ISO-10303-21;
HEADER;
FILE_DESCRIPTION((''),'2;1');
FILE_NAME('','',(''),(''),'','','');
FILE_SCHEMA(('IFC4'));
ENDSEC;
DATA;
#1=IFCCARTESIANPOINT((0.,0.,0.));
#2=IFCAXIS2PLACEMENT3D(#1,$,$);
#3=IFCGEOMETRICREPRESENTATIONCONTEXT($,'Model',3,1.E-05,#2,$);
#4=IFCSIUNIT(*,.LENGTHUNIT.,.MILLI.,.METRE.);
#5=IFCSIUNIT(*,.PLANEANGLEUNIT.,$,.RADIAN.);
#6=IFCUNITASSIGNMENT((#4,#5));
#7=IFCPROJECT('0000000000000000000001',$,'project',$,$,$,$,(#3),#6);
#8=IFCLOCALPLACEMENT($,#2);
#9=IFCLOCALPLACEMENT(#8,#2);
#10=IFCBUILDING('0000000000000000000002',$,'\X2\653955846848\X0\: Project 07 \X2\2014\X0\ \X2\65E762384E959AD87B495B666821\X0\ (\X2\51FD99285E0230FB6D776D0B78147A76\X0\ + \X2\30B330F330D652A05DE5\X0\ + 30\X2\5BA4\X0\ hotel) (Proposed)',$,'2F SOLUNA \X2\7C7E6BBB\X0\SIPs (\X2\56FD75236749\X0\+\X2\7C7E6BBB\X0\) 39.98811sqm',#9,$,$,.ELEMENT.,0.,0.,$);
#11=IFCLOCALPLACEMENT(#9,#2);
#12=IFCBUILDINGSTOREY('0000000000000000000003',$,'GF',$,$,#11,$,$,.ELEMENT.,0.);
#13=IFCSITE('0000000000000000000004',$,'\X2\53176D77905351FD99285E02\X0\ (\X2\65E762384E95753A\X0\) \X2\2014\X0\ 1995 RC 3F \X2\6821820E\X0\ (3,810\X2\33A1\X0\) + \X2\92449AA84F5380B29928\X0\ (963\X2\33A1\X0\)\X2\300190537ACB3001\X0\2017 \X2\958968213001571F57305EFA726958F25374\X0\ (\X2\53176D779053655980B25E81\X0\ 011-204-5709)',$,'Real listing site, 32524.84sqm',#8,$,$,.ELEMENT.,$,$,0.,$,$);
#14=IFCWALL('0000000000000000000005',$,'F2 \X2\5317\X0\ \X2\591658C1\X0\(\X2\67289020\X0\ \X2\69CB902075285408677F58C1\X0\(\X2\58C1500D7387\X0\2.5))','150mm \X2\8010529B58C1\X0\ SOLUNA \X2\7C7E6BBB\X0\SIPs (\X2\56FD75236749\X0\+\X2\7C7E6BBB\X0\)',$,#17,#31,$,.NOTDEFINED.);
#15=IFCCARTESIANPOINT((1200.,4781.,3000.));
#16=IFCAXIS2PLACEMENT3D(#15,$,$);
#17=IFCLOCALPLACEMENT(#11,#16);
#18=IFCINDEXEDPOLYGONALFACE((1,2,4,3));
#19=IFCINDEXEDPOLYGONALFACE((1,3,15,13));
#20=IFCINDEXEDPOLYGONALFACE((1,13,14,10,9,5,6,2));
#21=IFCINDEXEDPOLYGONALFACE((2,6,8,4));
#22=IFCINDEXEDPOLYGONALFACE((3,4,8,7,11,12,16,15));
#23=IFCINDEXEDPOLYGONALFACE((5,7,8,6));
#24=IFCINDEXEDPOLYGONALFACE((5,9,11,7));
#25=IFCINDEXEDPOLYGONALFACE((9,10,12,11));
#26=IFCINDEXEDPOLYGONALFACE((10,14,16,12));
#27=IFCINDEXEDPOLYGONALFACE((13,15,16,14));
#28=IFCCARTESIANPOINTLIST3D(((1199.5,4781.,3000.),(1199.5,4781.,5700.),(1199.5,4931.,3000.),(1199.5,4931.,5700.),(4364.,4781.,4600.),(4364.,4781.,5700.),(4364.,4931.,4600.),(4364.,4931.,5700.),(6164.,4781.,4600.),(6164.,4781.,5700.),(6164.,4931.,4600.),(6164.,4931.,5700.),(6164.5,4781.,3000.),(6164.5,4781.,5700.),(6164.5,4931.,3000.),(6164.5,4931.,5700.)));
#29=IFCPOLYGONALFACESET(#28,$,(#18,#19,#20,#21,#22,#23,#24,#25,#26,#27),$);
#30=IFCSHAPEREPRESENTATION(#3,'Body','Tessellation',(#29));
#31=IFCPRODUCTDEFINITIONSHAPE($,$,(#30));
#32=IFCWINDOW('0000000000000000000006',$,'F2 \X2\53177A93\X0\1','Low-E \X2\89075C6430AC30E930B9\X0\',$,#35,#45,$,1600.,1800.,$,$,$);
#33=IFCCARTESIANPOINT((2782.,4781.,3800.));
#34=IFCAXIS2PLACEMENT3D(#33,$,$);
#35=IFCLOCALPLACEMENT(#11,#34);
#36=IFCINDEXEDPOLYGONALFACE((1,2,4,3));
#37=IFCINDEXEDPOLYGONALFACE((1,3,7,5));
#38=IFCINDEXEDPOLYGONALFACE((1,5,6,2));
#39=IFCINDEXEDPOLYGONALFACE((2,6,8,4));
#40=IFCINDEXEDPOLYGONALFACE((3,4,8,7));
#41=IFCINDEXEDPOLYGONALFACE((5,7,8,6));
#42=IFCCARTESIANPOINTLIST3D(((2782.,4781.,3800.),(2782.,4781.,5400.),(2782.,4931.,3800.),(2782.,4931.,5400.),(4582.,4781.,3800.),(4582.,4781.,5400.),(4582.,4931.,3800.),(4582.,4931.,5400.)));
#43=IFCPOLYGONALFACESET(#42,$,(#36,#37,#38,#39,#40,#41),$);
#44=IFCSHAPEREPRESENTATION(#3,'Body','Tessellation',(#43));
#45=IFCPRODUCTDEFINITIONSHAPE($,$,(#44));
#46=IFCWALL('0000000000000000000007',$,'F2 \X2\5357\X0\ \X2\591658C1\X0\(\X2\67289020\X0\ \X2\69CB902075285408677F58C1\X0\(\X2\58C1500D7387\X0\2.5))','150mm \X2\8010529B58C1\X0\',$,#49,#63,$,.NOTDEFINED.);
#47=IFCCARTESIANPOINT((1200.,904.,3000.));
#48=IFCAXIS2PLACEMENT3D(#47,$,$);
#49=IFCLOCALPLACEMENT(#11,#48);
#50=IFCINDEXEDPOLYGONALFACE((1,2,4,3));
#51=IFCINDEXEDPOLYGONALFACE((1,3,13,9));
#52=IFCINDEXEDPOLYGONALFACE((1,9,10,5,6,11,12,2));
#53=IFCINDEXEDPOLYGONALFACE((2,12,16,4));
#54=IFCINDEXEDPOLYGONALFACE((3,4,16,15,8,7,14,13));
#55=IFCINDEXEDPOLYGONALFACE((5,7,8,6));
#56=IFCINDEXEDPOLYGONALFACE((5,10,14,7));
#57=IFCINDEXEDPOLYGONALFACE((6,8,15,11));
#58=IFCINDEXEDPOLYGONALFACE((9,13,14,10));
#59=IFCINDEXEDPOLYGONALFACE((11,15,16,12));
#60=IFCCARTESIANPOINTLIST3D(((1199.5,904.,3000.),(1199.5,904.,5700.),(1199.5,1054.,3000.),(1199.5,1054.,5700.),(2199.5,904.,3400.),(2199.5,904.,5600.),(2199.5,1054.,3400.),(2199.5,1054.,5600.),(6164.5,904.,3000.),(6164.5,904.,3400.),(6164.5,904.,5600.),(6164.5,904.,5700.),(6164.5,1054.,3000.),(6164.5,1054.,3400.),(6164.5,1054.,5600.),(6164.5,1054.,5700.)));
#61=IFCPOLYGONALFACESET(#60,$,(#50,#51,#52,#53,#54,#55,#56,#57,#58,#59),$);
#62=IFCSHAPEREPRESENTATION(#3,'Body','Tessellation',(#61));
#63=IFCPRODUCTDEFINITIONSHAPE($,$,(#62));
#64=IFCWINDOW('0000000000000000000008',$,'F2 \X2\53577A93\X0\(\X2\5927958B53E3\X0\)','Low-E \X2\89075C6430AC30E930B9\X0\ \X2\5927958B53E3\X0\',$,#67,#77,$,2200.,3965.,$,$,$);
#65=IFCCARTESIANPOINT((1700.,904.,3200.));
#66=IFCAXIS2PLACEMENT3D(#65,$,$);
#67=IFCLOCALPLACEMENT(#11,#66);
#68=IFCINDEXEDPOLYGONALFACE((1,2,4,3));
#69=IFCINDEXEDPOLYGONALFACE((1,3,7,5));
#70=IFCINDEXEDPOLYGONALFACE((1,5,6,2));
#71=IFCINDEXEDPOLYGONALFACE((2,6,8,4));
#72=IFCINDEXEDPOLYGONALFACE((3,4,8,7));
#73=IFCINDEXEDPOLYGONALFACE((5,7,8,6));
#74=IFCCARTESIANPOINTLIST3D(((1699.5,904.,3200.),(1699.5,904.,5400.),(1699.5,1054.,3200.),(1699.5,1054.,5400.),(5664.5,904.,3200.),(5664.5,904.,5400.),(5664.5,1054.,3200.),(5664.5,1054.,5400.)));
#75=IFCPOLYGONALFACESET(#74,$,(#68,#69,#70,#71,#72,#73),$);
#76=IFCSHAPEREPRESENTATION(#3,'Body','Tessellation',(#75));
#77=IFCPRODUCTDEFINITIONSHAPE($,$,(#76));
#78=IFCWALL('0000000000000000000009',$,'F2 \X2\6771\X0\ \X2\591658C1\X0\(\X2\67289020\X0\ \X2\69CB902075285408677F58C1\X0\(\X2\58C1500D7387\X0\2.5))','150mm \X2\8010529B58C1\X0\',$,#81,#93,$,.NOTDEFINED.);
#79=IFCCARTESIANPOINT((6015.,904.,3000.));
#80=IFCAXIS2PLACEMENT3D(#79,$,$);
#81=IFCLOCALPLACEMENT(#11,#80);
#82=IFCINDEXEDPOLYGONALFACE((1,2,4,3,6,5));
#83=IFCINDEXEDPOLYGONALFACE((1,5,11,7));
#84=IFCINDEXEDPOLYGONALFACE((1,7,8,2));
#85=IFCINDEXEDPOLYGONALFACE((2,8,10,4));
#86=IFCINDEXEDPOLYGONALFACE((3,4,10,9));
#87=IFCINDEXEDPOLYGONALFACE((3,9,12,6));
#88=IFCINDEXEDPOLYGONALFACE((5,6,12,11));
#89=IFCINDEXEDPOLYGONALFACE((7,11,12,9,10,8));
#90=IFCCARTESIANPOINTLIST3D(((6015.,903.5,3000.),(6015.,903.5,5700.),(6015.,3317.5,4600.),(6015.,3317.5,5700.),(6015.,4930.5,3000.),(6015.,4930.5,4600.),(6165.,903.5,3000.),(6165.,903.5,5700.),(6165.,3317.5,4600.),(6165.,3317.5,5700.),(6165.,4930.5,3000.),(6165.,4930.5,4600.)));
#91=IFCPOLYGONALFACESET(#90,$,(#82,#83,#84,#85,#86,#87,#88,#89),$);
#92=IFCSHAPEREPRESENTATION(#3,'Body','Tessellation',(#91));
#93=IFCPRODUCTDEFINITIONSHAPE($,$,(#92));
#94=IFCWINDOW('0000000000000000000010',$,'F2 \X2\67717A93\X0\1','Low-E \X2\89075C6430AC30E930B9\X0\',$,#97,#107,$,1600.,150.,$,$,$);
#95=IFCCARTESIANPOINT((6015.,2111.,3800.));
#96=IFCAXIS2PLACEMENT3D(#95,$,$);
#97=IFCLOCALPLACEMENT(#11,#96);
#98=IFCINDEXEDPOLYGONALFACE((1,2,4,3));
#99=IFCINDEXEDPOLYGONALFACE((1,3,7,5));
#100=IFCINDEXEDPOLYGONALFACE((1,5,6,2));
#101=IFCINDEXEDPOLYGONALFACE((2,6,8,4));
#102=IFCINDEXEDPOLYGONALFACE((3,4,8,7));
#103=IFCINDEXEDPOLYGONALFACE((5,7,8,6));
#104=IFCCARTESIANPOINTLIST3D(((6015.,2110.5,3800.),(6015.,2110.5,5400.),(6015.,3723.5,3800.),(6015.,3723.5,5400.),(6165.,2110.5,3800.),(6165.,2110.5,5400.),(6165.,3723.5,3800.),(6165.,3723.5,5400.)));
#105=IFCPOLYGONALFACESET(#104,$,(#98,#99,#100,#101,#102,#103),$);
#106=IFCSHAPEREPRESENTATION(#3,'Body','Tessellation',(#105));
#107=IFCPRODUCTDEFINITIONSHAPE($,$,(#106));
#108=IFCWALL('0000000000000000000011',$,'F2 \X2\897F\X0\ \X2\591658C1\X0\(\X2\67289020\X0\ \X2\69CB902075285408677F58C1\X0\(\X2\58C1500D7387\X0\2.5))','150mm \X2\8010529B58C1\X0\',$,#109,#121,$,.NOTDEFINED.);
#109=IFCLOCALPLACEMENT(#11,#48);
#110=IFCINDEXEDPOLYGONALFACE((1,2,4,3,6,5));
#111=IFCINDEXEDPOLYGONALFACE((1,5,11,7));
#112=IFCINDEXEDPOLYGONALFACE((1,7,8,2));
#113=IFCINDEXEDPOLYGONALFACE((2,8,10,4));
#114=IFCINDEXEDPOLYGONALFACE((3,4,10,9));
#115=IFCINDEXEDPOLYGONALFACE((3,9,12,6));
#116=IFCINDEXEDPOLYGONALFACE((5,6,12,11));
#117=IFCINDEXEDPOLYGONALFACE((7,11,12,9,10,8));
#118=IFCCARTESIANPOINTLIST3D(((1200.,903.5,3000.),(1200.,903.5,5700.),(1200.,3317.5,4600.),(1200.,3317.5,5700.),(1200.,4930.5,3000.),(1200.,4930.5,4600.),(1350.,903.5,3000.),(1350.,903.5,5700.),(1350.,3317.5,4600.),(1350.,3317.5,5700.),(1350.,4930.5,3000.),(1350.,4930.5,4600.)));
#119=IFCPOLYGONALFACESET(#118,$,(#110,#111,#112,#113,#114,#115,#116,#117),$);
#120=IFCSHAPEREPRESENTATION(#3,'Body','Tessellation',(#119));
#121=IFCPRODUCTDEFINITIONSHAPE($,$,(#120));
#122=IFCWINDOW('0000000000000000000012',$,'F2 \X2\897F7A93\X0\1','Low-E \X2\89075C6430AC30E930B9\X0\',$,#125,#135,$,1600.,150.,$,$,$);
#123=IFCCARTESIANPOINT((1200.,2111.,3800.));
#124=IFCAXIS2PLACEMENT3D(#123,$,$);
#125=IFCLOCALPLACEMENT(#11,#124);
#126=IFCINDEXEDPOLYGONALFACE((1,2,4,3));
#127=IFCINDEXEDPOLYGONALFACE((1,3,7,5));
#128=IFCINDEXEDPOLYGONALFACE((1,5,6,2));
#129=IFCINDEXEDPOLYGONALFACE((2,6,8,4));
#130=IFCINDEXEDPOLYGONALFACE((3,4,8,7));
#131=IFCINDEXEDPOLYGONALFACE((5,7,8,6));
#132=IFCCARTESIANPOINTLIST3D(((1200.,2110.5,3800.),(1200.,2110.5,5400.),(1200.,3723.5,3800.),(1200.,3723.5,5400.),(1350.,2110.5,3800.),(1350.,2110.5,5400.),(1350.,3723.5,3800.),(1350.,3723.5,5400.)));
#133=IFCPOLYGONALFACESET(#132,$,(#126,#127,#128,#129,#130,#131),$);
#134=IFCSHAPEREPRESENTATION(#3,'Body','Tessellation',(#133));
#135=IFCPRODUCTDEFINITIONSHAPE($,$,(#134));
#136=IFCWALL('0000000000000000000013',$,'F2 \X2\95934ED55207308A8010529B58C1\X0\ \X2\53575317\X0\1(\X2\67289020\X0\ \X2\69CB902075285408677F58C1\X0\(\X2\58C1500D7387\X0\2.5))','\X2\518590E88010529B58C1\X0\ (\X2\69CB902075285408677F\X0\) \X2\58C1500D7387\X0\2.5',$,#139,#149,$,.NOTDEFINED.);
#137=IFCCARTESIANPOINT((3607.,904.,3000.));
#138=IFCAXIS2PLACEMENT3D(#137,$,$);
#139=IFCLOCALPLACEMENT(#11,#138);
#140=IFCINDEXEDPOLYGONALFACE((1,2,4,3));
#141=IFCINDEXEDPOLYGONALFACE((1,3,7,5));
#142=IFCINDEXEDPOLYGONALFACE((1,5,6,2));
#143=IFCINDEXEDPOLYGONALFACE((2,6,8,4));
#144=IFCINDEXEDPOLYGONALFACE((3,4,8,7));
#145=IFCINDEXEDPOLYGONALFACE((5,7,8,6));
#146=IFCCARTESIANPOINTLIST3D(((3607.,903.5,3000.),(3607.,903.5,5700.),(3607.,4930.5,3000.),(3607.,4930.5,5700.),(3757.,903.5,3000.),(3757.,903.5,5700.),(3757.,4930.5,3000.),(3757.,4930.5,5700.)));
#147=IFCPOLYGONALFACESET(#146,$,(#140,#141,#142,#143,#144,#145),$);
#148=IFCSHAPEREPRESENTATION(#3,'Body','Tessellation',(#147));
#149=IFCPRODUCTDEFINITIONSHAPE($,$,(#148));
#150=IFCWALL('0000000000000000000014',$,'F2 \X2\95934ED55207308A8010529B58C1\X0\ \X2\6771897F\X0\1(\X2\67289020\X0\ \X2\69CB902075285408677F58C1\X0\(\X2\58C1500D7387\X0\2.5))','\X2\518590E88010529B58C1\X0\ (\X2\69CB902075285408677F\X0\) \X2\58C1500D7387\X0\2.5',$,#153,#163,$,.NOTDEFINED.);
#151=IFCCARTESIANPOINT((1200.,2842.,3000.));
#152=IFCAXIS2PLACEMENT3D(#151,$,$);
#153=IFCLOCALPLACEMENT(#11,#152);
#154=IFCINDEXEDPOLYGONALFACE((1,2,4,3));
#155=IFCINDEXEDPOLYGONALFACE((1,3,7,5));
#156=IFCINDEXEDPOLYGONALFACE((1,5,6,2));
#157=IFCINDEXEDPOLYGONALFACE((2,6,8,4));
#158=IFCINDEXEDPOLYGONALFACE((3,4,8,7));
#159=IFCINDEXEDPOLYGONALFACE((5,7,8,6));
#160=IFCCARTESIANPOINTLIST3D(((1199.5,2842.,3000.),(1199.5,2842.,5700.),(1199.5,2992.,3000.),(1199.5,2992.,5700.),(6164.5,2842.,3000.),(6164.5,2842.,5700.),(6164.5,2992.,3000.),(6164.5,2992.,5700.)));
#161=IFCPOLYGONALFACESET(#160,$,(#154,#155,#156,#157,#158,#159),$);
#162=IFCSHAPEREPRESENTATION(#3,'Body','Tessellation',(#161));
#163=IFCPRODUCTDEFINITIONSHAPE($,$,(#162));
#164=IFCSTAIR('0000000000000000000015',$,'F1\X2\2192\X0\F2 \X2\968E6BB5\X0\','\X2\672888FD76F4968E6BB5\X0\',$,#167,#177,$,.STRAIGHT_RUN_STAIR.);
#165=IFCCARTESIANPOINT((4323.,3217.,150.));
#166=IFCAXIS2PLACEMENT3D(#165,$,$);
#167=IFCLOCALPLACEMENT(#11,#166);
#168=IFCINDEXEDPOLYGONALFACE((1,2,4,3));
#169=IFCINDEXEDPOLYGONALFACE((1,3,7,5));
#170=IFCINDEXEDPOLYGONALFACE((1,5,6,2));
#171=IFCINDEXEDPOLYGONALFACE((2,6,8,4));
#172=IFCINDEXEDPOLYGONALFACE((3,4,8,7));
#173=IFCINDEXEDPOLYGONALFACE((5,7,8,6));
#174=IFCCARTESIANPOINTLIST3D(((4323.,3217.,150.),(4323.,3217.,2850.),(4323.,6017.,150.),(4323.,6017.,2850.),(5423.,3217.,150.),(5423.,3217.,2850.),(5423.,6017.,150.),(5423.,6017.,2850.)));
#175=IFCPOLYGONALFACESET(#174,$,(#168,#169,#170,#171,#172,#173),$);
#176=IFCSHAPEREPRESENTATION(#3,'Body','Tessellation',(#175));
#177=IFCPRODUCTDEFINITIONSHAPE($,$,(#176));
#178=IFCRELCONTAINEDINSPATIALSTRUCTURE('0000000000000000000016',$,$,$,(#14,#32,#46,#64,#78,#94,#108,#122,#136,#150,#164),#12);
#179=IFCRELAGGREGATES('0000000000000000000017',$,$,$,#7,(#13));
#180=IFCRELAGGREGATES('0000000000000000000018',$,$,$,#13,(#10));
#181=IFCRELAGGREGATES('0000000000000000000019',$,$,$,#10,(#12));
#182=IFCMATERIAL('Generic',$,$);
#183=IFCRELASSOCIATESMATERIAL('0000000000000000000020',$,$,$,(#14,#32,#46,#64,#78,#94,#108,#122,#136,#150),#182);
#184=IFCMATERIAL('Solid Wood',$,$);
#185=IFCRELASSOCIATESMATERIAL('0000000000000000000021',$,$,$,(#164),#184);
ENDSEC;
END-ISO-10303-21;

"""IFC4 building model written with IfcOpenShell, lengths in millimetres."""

from ifc_helpers import new_model, si_unit, frame, frame_2d, origin, place, context, project, spatial, rectangle, extrude, material, element, fill, save


model = new_model("IFC4")

# Units and contexts
model_context = context("Model", 3, precision=1e-05, world=origin())
ifc_project = project(units=[si_unit("LENGTHUNIT", "METRE", prefix="MILLI"), si_unit("PLANEANGLEUNIT", "RADIAN")], contexts=[model_context])

# Site, building, storey
site_placement = place(None, origin())
site = spatial("IfcSite", under=ifc_project, at=site_placement, Name="北海道函館市 (旧戸井町) — 1995 RC 3F 校舎 (3,810㎡) + 鉄骨体育館 (963㎡)、道立、2017 閉校、土地建物売却 (北海道教育庁 011-204-5709)", ObjectType="Real listing site, 32524.84sqm", CompositionType="ELEMENT", RefElevation=0.0)
building_placement = place(site_placement, origin())
building = spatial("IfcBuilding", under=site, at=building_placement, Name="改善案: Project 07 — 旧戸井高等学校 (函館市・海洋研究 + コンブ加工 + 30室 hotel) (Proposed)", ObjectType="2F SOLUNA 籾殻SIPs (国産杉+籾殻) 39.98811sqm", CompositionType="ELEMENT", ElevationOfRefHeight=0.0, ElevationOfTerrain=0.0)
storey_placement = place(building_placement, origin())
storey = spatial("IfcBuildingStorey", under=building, at=storey_placement, Name="GF", CompositionType="ELEMENT", Elevation=0.0)

# Shared definitions
ifc_material_1 = material(Name="Generic")

# Shared definitions
ifc_material_2 = material(Name="Solid Wood")

# Walls, openings, windows
wall_1_placement = place(storey_placement, frame((1200.0, 4781.0, 3000.0)))
wall_1 = element("IfcWall", 1, at=wall_1_placement, inside=storey, material=ifc_material_1, Name="F2 北 外壁(木造 構造用合板壁(壁倍率2.5))", Description="150mm 耐力壁 SOLUNA 籾殻SIPs (国産杉+籾殻)", PredefinedType="NOTDEFINED", context=model_context, shape_type="SweptSolid", body=[
    extrude(rectangle(XDim=4965.0, YDim=150.0, at=frame_2d((2482.0, 75.0))), frame((1200.0, 4781.0, 3000.0)), (0.0, 0.0, 1.0), 2700.0),
])
opening_1_placement = place(storey_placement, frame((2782.0, 4781.0, 3800.0)))
opening_1 = element("IfcOpeningElement", 2, at=opening_1_placement, cuts=wall_1, PredefinedType="NOTDEFINED", context=model_context, shape_type="SweptSolid", body=[
    extrude(rectangle(XDim=1800.0, YDim=150.0, at=frame_2d((900.0, 75.0))), frame((2782.0, 4781.0, 3800.0)), (0.0, 0.0, 1.0), 1600.0),
])
window_1_placement = place(storey_placement, frame((2782.0, 4781.0, 3800.0)))
window_1 = element("IfcWindow", 3, at=window_1_placement, inside=storey, material=ifc_material_1, Name="F2 北窓1", Description="Low-E 複層ガラス", OverallHeight=1600.0, OverallWidth=1800.0, context=model_context, shape_type="SweptSolid", body=[
    extrude(rectangle(XDim=1800.0, YDim=150.0, at=frame_2d((900.0, 75.0))), frame((2782.0, 4781.0, 3800.0)), (0.0, 0.0, 1.0), 1600.0),
])
fill(opening_1, window_1)
wall_2_placement = place(storey_placement, frame((1200.0, 904.0, 3000.0)))
wall_2 = element("IfcWall", 4, at=wall_2_placement, inside=storey, material=ifc_material_1, Name="F2 南 外壁(木造 構造用合板壁(壁倍率2.5))", Description="150mm 耐力壁", PredefinedType="NOTDEFINED", context=model_context, shape_type="SweptSolid", body=[
    extrude(rectangle(XDim=4965.0, YDim=150.0, at=frame_2d((2482.0, 75.0))), frame((1200.0, 904.0, 3000.0)), (0.0, 0.0, 1.0), 2700.0),
])
opening_2_placement = place(storey_placement, frame((1700.0, 904.0, 3200.0)))
opening_2 = element("IfcOpeningElement", 5, at=opening_2_placement, cuts=wall_2, PredefinedType="NOTDEFINED", context=model_context, shape_type="SweptSolid", body=[
    extrude(rectangle(XDim=3965.0, YDim=150.0, at=frame_2d((1982.0, 75.0))), frame((1700.0, 904.0, 3200.0)), (0.0, 0.0, 1.0), 2200.0),
])
window_2_placement = place(storey_placement, frame((1700.0, 904.0, 3200.0)))
window_2 = element("IfcWindow", 6, at=window_2_placement, inside=storey, material=ifc_material_1, Name="F2 南窓(大開口)", Description="Low-E 複層ガラス 大開口", OverallHeight=2200.0, OverallWidth=3965.0, context=model_context, shape_type="SweptSolid", body=[
    extrude(rectangle(XDim=3965.0, YDim=150.0, at=frame_2d((1982.0, 75.0))), frame((1700.0, 904.0, 3200.0)), (0.0, 0.0, 1.0), 2200.0),
])
fill(opening_2, window_2)
wall_3_placement = place(storey_placement, frame((6015.0, 904.0, 3000.0)))
wall_3 = element("IfcWall", 7, at=wall_3_placement, inside=storey, material=ifc_material_1, Name="F2 東 外壁(木造 構造用合板壁(壁倍率2.5))", Description="150mm 耐力壁", PredefinedType="NOTDEFINED", context=model_context, shape_type="SweptSolid", body=[
    extrude(rectangle(XDim=150.0, YDim=4027.0, at=frame_2d((75.0, 2013.0))), frame((6015.0, 904.0, 3000.0)), (0.0, 0.0, 1.0), 2700.0),
])
opening_3_placement = place(storey_placement, frame((6015.0, 2111.0, 3800.0)))
opening_3 = element("IfcOpeningElement", 8, at=opening_3_placement, cuts=wall_3, PredefinedType="NOTDEFINED", context=model_context, shape_type="SweptSolid", body=[
    extrude(rectangle(XDim=150.0, YDim=1613.0, at=frame_2d((75.0, 806.0))), frame((6015.0, 2111.0, 3800.0)), (0.0, 0.0, 1.0), 1600.0),
])
window_3_placement = place(storey_placement, frame((6015.0, 2111.0, 3800.0)))
window_3 = element("IfcWindow", 9, at=window_3_placement, inside=storey, material=ifc_material_1, Name="F2 東窓1", Description="Low-E 複層ガラス", OverallHeight=1600.0, OverallWidth=150.0, context=model_context, shape_type="SweptSolid", body=[
    extrude(rectangle(XDim=150.0, YDim=1613.0, at=frame_2d((75.0, 806.0))), frame((6015.0, 2111.0, 3800.0)), (0.0, 0.0, 1.0), 1600.0),
])
fill(opening_3, window_3)
wall_4_placement = place(storey_placement, frame((1200.0, 904.0, 3000.0)))
wall_4 = element("IfcWall", 10, at=wall_4_placement, inside=storey, material=ifc_material_1, Name="F2 西 外壁(木造 構造用合板壁(壁倍率2.5))", Description="150mm 耐力壁", PredefinedType="NOTDEFINED", context=model_context, shape_type="SweptSolid", body=[
    extrude(rectangle(XDim=150.0, YDim=4027.0, at=frame_2d((75.0, 2013.0))), frame((1200.0, 904.0, 3000.0)), (0.0, 0.0, 1.0), 2700.0),
])
opening_4_placement = place(storey_placement, frame((1200.0, 2111.0, 3800.0)))
opening_4 = element("IfcOpeningElement", 11, at=opening_4_placement, cuts=wall_4, PredefinedType="NOTDEFINED", context=model_context, shape_type="SweptSolid", body=[
    extrude(rectangle(XDim=150.0, YDim=1613.0, at=frame_2d((75.0, 806.0))), frame((1200.0, 2111.0, 3800.0)), (0.0, 0.0, 1.0), 1600.0),
])
window_4_placement = place(storey_placement, frame((1200.0, 2111.0, 3800.0)))
window_4 = element("IfcWindow", 12, at=window_4_placement, inside=storey, material=ifc_material_1, Name="F2 西窓1", Description="Low-E 複層ガラス", OverallHeight=1600.0, OverallWidth=150.0, context=model_context, shape_type="SweptSolid", body=[
    extrude(rectangle(XDim=150.0, YDim=1613.0, at=frame_2d((75.0, 806.0))), frame((1200.0, 2111.0, 3800.0)), (0.0, 0.0, 1.0), 1600.0),
])
fill(opening_4, window_4)

# Walls
wall_5_placement = place(storey_placement, frame((3607.0, 904.0, 3000.0)))
element("IfcWall", 13, at=wall_5_placement, inside=storey, material=ifc_material_1, Name="F2 間仕切り耐力壁 南北1(木造 構造用合板壁(壁倍率2.5))", Description="内部耐力壁 (構造用合板) 壁倍率2.5", PredefinedType="NOTDEFINED", context=model_context, shape_type="SweptSolid", body=[
    extrude(rectangle(XDim=150.0, YDim=4027.0, at=frame_2d((75.0, 2013.0))), frame((3607.0, 904.0, 3000.0)), (0.0, 0.0, 1.0), 2700.0),
])
wall_6_placement = place(storey_placement, frame((1200.0, 2842.0, 3000.0)))
element("IfcWall", 14, at=wall_6_placement, inside=storey, material=ifc_material_1, Name="F2 間仕切り耐力壁 東西1(木造 構造用合板壁(壁倍率2.5))", Description="内部耐力壁 (構造用合板) 壁倍率2.5", PredefinedType="NOTDEFINED", context=model_context, shape_type="SweptSolid", body=[
    extrude(rectangle(XDim=4965.0, YDim=150.0, at=frame_2d((2482.0, 75.0))), frame((1200.0, 2842.0, 3000.0)), (0.0, 0.0, 1.0), 2700.0),
])

# Stair
stair_placement = place(storey_placement, frame((4323.0, 3217.0, 150.0)))
element("IfcStair", 15, at=stair_placement, inside=storey, material=ifc_material_2, Name="F1→F2 階段", Description="木製直階段", PredefinedType="STRAIGHT_RUN_STAIR", context=model_context, shape_type="SweptSolid", body=[
    extrude(rectangle(XDim=1100.0, YDim=2800.0, at=frame_2d((550.0, 1400.0))), frame((4323.0, 3217.0, 150.0)), (0.0, 0.0, 1.0), 2700.0),
])

save(model, "model.ifc")
